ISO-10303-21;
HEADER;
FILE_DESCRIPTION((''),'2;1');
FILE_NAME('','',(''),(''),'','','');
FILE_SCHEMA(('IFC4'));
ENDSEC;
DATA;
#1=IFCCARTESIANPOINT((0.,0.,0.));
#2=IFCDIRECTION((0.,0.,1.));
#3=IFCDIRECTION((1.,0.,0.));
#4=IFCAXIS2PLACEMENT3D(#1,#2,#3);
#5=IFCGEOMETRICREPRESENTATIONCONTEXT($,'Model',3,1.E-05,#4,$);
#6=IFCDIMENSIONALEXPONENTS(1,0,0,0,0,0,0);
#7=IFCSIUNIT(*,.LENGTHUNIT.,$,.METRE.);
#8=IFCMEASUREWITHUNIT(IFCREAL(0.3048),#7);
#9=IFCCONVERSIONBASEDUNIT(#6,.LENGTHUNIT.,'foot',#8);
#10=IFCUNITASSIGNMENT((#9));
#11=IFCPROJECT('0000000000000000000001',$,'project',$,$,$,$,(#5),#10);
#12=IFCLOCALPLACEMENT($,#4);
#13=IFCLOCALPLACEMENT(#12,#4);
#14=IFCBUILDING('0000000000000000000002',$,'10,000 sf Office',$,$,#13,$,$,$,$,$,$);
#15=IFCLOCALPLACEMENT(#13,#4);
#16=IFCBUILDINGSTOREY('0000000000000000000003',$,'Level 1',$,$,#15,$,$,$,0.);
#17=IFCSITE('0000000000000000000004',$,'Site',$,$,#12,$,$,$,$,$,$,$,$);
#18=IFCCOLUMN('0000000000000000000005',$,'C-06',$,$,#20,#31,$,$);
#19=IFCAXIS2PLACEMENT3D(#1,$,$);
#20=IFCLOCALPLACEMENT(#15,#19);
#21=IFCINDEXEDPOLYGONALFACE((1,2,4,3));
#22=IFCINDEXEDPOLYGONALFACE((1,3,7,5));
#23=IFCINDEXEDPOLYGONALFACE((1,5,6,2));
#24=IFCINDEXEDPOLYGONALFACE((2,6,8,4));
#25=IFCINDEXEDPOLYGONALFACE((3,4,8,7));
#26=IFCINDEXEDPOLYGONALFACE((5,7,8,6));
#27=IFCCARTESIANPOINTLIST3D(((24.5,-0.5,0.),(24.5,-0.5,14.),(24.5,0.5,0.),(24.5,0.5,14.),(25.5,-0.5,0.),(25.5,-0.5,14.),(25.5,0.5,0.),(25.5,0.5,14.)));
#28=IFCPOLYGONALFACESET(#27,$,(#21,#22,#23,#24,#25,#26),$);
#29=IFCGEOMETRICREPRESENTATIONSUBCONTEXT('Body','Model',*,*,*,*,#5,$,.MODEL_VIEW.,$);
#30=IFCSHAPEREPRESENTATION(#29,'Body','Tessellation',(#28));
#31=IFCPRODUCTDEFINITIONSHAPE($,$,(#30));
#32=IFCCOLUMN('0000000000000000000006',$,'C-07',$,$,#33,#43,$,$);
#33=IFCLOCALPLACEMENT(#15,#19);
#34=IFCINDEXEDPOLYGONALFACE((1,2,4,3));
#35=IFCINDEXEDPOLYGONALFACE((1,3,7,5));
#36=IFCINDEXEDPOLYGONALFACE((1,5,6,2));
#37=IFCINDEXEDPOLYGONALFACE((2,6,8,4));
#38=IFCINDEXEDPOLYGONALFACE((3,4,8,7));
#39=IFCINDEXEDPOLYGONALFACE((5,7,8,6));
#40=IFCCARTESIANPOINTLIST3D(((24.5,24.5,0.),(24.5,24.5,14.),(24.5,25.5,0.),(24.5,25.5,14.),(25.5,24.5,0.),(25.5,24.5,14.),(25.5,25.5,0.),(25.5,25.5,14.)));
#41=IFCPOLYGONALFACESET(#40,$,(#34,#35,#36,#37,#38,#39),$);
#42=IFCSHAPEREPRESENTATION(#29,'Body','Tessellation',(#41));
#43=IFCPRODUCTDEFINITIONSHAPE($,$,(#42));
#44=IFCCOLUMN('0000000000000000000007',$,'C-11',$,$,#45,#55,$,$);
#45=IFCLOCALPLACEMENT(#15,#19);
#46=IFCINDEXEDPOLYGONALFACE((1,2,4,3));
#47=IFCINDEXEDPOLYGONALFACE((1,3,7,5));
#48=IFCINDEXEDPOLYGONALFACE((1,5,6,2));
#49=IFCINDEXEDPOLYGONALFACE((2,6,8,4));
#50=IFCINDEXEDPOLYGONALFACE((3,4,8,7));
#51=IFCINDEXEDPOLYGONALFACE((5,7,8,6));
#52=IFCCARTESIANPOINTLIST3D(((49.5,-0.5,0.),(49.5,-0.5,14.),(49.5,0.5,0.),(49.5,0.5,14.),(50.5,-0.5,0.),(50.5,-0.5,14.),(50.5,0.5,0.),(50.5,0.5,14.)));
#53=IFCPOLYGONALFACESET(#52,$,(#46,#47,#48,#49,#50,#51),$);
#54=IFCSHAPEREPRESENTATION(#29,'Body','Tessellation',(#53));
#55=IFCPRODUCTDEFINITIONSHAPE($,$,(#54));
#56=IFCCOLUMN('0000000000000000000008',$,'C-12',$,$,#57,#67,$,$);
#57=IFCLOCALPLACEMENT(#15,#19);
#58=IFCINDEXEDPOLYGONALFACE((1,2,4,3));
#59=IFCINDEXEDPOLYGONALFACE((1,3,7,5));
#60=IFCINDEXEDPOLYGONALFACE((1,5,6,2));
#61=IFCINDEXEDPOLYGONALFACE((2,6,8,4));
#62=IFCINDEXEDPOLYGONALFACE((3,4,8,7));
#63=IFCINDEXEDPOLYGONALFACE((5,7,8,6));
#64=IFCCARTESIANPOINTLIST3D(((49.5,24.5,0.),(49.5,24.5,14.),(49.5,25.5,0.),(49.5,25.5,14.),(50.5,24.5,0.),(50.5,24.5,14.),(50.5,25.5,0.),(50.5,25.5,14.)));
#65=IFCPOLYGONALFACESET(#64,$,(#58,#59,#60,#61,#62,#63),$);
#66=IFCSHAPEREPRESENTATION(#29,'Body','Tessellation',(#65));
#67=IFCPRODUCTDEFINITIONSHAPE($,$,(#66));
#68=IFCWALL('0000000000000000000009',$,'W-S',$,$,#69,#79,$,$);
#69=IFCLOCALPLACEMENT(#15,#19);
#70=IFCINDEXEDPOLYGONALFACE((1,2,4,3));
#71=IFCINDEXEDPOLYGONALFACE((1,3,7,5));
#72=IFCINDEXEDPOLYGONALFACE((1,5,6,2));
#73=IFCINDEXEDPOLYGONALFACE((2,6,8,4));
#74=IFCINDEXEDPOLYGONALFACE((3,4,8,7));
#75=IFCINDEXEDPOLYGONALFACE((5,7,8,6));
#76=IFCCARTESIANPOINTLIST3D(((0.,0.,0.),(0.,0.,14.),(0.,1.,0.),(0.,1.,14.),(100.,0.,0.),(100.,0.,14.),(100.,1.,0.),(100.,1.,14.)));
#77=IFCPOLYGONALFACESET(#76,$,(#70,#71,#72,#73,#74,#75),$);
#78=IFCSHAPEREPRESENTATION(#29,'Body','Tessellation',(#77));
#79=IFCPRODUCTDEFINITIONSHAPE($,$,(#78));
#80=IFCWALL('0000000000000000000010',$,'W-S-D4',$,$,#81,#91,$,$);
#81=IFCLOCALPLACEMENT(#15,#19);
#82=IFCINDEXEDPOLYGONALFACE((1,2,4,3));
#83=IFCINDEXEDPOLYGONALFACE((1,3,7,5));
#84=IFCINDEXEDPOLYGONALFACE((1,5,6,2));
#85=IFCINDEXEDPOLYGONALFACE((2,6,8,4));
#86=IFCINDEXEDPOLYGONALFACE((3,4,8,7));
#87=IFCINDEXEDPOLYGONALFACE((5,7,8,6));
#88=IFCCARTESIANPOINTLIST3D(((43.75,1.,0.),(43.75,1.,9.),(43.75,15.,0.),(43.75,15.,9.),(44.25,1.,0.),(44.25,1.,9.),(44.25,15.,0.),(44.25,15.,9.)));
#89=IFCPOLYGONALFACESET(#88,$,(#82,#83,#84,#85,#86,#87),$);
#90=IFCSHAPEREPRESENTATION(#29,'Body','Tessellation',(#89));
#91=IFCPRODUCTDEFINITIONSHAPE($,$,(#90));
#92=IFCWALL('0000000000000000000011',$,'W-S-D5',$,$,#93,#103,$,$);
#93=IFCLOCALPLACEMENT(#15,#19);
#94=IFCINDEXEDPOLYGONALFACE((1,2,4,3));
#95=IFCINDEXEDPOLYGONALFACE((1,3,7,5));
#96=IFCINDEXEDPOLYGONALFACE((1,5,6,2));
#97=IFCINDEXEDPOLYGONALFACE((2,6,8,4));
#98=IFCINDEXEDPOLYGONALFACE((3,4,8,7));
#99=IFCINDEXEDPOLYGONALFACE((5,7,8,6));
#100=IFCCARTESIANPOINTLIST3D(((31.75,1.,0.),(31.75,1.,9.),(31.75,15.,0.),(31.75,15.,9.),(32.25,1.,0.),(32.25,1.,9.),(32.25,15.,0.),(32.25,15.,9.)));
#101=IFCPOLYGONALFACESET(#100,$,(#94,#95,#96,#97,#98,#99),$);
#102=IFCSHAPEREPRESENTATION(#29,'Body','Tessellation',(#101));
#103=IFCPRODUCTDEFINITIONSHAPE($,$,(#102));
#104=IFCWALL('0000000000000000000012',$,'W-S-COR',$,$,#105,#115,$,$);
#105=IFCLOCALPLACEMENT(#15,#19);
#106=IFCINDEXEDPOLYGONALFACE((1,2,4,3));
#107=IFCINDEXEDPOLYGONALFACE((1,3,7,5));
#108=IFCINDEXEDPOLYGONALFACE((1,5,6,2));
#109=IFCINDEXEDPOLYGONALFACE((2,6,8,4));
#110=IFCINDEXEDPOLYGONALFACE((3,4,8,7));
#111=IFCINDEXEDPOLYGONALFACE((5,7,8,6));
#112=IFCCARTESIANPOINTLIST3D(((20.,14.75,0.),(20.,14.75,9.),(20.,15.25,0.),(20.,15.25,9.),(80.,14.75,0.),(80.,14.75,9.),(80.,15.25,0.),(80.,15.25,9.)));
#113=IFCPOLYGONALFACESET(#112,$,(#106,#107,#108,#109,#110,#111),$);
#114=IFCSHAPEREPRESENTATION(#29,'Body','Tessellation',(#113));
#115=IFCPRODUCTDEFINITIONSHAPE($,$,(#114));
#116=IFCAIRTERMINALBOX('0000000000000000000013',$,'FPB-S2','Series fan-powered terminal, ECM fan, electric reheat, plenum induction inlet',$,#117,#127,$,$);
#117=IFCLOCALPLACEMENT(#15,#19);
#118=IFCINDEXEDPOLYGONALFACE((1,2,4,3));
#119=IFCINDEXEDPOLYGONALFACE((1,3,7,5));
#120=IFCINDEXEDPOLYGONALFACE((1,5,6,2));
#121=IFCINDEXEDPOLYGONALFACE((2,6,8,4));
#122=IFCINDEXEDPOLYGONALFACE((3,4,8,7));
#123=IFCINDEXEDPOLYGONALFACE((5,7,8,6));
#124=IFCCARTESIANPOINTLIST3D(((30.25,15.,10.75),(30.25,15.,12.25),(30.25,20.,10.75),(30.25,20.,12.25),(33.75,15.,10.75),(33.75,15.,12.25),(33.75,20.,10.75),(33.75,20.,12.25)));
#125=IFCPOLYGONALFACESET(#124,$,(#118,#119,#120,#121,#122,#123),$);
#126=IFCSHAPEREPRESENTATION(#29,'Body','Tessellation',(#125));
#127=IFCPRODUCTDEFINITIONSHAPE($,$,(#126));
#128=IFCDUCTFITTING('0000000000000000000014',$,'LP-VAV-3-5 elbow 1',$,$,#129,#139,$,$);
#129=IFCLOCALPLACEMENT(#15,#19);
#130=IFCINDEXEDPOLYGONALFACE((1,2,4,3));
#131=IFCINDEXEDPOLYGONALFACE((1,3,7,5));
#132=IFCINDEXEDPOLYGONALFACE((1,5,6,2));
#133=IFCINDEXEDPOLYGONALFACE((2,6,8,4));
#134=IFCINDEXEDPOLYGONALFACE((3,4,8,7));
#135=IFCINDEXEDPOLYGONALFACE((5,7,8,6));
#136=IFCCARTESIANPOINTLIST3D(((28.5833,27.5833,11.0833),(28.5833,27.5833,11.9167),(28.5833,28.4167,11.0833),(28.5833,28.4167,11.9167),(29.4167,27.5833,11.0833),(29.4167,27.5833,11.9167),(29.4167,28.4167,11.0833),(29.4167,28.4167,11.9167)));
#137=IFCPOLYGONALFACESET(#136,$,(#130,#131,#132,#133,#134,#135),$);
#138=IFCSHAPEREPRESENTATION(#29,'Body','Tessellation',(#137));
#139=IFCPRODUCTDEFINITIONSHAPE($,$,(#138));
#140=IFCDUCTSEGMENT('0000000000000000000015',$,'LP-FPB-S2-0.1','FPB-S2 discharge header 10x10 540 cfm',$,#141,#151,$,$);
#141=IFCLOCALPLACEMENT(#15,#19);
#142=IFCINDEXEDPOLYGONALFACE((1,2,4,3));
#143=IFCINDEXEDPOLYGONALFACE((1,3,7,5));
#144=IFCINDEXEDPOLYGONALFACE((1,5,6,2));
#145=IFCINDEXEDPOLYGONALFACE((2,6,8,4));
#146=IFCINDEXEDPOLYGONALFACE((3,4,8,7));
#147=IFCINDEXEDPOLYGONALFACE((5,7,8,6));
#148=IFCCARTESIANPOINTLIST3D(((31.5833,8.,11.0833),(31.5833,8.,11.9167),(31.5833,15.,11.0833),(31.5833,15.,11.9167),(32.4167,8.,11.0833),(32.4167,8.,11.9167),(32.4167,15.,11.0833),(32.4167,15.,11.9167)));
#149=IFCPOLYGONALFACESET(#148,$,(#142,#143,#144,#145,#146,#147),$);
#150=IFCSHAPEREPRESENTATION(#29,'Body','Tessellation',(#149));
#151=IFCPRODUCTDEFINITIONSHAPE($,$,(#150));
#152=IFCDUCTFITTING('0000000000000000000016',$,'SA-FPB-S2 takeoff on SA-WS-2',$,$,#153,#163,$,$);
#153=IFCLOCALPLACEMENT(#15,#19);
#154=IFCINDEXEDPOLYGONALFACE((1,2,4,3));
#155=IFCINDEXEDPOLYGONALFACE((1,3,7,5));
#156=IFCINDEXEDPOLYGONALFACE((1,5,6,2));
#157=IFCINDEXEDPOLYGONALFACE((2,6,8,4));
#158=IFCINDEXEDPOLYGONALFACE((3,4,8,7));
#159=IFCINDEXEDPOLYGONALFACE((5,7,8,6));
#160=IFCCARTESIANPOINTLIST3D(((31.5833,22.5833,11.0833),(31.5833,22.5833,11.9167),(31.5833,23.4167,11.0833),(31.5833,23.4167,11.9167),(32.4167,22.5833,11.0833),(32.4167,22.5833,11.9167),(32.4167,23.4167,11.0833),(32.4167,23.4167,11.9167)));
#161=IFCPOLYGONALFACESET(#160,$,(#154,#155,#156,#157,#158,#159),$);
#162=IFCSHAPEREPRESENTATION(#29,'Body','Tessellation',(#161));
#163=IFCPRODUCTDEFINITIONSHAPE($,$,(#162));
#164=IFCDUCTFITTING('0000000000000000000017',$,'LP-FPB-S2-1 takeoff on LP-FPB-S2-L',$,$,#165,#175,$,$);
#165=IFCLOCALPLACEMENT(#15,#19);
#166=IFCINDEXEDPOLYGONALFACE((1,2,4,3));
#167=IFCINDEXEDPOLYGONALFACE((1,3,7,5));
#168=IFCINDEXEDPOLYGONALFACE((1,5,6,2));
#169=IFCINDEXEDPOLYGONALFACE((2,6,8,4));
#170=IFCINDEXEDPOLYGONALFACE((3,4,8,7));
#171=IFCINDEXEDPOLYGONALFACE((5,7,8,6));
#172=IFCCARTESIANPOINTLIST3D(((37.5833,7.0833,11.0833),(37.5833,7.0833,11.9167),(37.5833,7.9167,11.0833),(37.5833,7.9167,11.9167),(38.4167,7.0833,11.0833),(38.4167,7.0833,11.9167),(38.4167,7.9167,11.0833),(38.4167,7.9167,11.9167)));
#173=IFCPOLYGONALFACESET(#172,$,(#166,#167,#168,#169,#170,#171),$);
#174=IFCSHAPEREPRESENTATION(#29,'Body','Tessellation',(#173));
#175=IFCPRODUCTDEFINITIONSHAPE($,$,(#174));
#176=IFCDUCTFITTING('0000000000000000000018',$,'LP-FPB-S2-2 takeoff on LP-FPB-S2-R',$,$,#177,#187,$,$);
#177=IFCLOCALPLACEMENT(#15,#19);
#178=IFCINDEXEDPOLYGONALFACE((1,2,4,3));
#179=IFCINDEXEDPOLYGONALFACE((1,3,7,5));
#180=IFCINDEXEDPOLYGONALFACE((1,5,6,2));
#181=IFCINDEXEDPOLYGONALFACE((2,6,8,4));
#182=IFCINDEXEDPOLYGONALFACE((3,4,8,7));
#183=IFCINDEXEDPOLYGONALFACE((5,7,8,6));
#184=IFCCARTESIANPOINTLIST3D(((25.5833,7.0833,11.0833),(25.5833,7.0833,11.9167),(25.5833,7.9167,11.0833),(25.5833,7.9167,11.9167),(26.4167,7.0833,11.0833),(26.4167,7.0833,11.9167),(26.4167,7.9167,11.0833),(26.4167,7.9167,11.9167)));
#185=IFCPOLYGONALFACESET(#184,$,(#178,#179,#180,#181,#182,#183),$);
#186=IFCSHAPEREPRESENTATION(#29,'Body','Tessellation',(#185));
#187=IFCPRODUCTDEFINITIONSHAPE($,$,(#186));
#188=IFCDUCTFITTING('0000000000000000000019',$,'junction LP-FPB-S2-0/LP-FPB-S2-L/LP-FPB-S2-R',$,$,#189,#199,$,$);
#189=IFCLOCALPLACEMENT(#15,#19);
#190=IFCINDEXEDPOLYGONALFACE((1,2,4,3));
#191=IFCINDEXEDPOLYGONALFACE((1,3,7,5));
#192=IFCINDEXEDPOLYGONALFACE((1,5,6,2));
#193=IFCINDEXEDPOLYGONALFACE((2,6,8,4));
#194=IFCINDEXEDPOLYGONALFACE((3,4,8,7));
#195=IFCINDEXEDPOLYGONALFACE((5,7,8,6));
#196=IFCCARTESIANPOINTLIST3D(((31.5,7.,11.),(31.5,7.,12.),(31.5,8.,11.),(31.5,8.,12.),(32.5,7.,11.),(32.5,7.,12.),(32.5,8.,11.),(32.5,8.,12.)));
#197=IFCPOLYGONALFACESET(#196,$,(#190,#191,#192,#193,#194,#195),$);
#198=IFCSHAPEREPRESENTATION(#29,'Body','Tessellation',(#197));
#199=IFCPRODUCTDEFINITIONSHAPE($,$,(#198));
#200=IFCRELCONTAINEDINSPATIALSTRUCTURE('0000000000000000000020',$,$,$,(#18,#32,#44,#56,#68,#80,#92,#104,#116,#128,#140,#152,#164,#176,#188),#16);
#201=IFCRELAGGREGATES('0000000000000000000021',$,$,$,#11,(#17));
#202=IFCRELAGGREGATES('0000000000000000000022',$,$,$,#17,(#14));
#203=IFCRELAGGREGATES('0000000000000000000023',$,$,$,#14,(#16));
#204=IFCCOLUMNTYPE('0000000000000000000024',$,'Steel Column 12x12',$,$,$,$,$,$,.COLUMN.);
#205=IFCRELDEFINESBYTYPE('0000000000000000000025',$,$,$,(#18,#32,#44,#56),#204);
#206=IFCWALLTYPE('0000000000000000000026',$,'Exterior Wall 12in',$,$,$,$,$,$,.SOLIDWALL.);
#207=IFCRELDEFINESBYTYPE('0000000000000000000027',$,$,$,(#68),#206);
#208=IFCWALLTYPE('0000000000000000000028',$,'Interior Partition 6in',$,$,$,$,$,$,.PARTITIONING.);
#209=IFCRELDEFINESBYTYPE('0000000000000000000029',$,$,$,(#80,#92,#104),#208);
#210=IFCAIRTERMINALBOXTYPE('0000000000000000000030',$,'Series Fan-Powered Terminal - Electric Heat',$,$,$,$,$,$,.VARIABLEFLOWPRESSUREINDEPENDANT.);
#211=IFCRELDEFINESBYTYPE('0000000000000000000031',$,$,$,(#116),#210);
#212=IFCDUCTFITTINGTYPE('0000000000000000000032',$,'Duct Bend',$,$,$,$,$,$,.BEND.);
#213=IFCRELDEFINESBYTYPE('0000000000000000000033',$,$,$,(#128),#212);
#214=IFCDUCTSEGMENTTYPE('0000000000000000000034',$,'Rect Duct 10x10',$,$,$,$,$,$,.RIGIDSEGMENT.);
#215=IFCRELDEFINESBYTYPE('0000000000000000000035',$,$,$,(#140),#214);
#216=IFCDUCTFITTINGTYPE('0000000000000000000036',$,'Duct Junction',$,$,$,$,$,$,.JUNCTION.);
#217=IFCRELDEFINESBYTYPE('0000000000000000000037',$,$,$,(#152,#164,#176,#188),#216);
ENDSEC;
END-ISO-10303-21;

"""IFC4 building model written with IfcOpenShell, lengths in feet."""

from ifc_helpers import new_model, entity, si_unit, converted_unit, frame, origin_with_axes, place, context, subcontext, project, spatial, rectangle, extrude, type_object, element, save


model = new_model("IFC4")

# Units and contexts
model_context = context("Model", 3, precision=1e-05, world=origin_with_axes())
body_context = subcontext(model_context, "Body", "Model", "MODEL_VIEW")
ifc_project = project(units=[converted_unit("LENGTHUNIT", "foot", entity("IfcReal", 0.3048), si_unit("LENGTHUNIT", "METRE"), dimensions=[1, 0, 0, 0, 0, 0, 0])], contexts=[model_context])

# Site, building, storey
site_placement = place(None, origin_with_axes())
site = spatial("IfcSite", under=ifc_project, at=site_placement, Name="Site")
building_placement = place(site_placement, origin_with_axes())
building = spatial("IfcBuilding", under=site, at=building_placement, Name="10,000 sf Office")
storey_placement = place(building_placement, origin_with_axes())
storey = spatial("IfcBuildingStorey", under=building, at=storey_placement, Name="Level 1", Elevation=0.0)

# Columns
column_type = type_object("IfcColumnType", Name="Steel Column 12x12", PredefinedType="COLUMN")
for number, where, z_axis, x_axis, name in (
    (1, (25.0, 0.0, 0.0), (0.0, 0.0, 1.0), (1.0, 0.0, 0.0), "C-06"),
    (2, (25.0, 25.0, 0.0), (0.0, 0.0, 1.0), (1.0, 0.0, 0.0), "C-07"),
    (3, (50.0, 0.0, 0.0), (0.0, 0.0, 1.0), (1.0, 0.0, 0.0), "C-11"),
    (4, (50.0, 25.0, 0.0), (0.0, 0.0, 1.0), (1.0, 0.0, 0.0), "C-12"),
):
    element("IfcColumn", number, at=place(storey_placement, frame(where, z_axis=z_axis, x_axis=x_axis)), inside=storey, type_object=column_type, Name=name, context=body_context, shape_type="SweptSolid", body=[
        extrude(rectangle(XDim=1.0, YDim=1.0), None, (0.0, 0.0, 1.0), 14.0),
    ])

# Walls
wall_type_1 = type_object("IfcWallType", Name="Exterior Wall 12in", PredefinedType="SOLIDWALL")
wall_1_placement = place(storey_placement, frame((50.0, 0.5, 0.0), z_axis=(0.0, 0.0, 1.0), x_axis=(1.0, 0.0, 0.0)))
element("IfcWall", 5, at=wall_1_placement, inside=storey, type_object=wall_type_1, Name="W-S", context=body_context, shape_type="SweptSolid", body=[
    extrude(rectangle(XDim=100.0, YDim=1.0), None, (0.0, 0.0, 1.0), 14.0),
])
wall_type_2 = type_object("IfcWallType", Name="Interior Partition 6in", PredefinedType="PARTITIONING")
for number, where, z_axis, x_axis, name in (
    (6, (44.0, 8.0, 0.0), (0.0, 0.0, 1.0), (0.0, 1.0, 0.0), "W-S-D4"),
    (7, (32.0, 8.0, 0.0), (0.0, 0.0, 1.0), (0.0, 1.0, 0.0), "W-S-D5"),
):
    element("IfcWall", number, at=place(storey_placement, frame(where, z_axis=z_axis, x_axis=x_axis)), inside=storey, type_object=wall_type_2, Name=name, context=body_context, shape_type="SweptSolid", body=[
        extrude(rectangle(XDim=14.0, YDim=0.5), None, (0.0, 0.0, 1.0), 9.0),
    ])
wall_2_placement = place(storey_placement, frame((50.0, 15.0, 0.0), z_axis=(0.0, 0.0, 1.0), x_axis=(-1.0, 0.0, 0.0)))
element("IfcWall", 8, at=wall_2_placement, inside=storey, type_object=wall_type_2, Name="W-S-COR", context=body_context, shape_type="SweptSolid", body=[
    extrude(rectangle(XDim=60.0, YDim=0.5), None, (0.0, 0.0, 1.0), 9.0),
])

# Air terminal box
air_terminal_box_type = type_object("IfcAirTerminalBoxType", Name="Series Fan-Powered Terminal - Electric Heat", PredefinedType="VARIABLEFLOWPRESSUREINDEPENDANT")
air_terminal_box_placement = place(storey_placement, frame((32.0, 17.5, 10.75), z_axis=(0.0, 0.0, 1.0), x_axis=(0.0, -1.0, 0.0)))
element("IfcAirTerminalBox", 9, at=air_terminal_box_placement, inside=storey, type_object=air_terminal_box_type, Name="FPB-S2", Description="Series fan-powered terminal, ECM fan, electric reheat, plenum induction inlet", context=body_context, shape_type="SweptSolid", body=[
    extrude(rectangle(XDim=5.0, YDim=3.5), None, (0.0, 0.0, 1.0), 1.5),
])

# Duct fitting
duct_fitting_type_1 = type_object("IfcDuctFittingType", Name="Duct Bend", PredefinedType="BEND")
duct_fitting_1_placement = place(storey_placement, frame((29.0, 28.0, 11.0833), z_axis=(0.0, 0.0, 1.0), x_axis=(1.0, 0.0, 0.0)))
element("IfcDuctFitting", 10, at=duct_fitting_1_placement, inside=storey, type_object=duct_fitting_type_1, Name="LP-VAV-3-5 elbow 1", context=body_context, shape_type="SweptSolid", body=[
    extrude(rectangle(XDim=0.8333, YDim=0.8333), None, (0.0, 0.0, 1.0), 0.8333),
])

# Duct segment
duct_segment_type_1 = type_object("IfcDuctSegmentType", Name="Rect Duct 10x10", PredefinedType="RIGIDSEGMENT")
duct_segment_1_placement = place(storey_placement, frame((32.0, 15.0, 11.5), z_axis=(0.0, -1.0, 0.0), x_axis=(1.0, 0.0, 0.0)))
element("IfcDuctSegment", 11, at=duct_segment_1_placement, inside=storey, type_object=duct_segment_type_1, Name="LP-FPB-S2-0.1", Description="FPB-S2 discharge header 10x10 540 cfm", context=body_context, shape_type="SweptSolid", body=[
    extrude(rectangle(XDim=0.8333, YDim=0.8333), None, (0.0, 0.0, 1.0), 7.0),
])

# Duct fittings
duct_fitting_type_2 = type_object("IfcDuctFittingType", Name="Duct Junction", PredefinedType="JUNCTION")
for number, where, z_axis, x_axis, name in (
    (12, (32.0, 23.0, 11.0833), (0.0, 0.0, 1.0), (1.0, 0.0, 0.0), "SA-FPB-S2 takeoff on SA-WS-2"),
    (13, (38.0, 7.5, 11.0833), (0.0, 0.0, 1.0), (1.0, 0.0, 0.0), "LP-FPB-S2-1 takeoff on LP-FPB-S2-L"),
    (14, (26.0, 7.5, 11.0833), (0.0, 0.0, 1.0), (1.0, 0.0, 0.0), "LP-FPB-S2-2 takeoff on LP-FPB-S2-R"),
):
    element("IfcDuctFitting", number, at=place(storey_placement, frame(where, z_axis=z_axis, x_axis=x_axis)), inside=storey, type_object=duct_fitting_type_2, Name=name, context=body_context, shape_type="SweptSolid", body=[
        extrude(rectangle(XDim=0.8333, YDim=0.8333), None, (0.0, 0.0, 1.0), 0.8333),
    ])
duct_fitting_2_placement = place(storey_placement, frame((32.0, 7.5, 11.0), z_axis=(0.0, 0.0, 1.0), x_axis=(1.0, 0.0, 0.0)))
element("IfcDuctFitting", 15, at=duct_fitting_2_placement, inside=storey, type_object=duct_fitting_type_2, Name="junction LP-FPB-S2-0/LP-FPB-S2-L/LP-FPB-S2-R", context=body_context, shape_type="SweptSolid", body=[
    extrude(rectangle(XDim=1.0, YDim=1.0), None, (0.0, 0.0, 1.0), 1.0),
])

save(model, "model.ifc")
